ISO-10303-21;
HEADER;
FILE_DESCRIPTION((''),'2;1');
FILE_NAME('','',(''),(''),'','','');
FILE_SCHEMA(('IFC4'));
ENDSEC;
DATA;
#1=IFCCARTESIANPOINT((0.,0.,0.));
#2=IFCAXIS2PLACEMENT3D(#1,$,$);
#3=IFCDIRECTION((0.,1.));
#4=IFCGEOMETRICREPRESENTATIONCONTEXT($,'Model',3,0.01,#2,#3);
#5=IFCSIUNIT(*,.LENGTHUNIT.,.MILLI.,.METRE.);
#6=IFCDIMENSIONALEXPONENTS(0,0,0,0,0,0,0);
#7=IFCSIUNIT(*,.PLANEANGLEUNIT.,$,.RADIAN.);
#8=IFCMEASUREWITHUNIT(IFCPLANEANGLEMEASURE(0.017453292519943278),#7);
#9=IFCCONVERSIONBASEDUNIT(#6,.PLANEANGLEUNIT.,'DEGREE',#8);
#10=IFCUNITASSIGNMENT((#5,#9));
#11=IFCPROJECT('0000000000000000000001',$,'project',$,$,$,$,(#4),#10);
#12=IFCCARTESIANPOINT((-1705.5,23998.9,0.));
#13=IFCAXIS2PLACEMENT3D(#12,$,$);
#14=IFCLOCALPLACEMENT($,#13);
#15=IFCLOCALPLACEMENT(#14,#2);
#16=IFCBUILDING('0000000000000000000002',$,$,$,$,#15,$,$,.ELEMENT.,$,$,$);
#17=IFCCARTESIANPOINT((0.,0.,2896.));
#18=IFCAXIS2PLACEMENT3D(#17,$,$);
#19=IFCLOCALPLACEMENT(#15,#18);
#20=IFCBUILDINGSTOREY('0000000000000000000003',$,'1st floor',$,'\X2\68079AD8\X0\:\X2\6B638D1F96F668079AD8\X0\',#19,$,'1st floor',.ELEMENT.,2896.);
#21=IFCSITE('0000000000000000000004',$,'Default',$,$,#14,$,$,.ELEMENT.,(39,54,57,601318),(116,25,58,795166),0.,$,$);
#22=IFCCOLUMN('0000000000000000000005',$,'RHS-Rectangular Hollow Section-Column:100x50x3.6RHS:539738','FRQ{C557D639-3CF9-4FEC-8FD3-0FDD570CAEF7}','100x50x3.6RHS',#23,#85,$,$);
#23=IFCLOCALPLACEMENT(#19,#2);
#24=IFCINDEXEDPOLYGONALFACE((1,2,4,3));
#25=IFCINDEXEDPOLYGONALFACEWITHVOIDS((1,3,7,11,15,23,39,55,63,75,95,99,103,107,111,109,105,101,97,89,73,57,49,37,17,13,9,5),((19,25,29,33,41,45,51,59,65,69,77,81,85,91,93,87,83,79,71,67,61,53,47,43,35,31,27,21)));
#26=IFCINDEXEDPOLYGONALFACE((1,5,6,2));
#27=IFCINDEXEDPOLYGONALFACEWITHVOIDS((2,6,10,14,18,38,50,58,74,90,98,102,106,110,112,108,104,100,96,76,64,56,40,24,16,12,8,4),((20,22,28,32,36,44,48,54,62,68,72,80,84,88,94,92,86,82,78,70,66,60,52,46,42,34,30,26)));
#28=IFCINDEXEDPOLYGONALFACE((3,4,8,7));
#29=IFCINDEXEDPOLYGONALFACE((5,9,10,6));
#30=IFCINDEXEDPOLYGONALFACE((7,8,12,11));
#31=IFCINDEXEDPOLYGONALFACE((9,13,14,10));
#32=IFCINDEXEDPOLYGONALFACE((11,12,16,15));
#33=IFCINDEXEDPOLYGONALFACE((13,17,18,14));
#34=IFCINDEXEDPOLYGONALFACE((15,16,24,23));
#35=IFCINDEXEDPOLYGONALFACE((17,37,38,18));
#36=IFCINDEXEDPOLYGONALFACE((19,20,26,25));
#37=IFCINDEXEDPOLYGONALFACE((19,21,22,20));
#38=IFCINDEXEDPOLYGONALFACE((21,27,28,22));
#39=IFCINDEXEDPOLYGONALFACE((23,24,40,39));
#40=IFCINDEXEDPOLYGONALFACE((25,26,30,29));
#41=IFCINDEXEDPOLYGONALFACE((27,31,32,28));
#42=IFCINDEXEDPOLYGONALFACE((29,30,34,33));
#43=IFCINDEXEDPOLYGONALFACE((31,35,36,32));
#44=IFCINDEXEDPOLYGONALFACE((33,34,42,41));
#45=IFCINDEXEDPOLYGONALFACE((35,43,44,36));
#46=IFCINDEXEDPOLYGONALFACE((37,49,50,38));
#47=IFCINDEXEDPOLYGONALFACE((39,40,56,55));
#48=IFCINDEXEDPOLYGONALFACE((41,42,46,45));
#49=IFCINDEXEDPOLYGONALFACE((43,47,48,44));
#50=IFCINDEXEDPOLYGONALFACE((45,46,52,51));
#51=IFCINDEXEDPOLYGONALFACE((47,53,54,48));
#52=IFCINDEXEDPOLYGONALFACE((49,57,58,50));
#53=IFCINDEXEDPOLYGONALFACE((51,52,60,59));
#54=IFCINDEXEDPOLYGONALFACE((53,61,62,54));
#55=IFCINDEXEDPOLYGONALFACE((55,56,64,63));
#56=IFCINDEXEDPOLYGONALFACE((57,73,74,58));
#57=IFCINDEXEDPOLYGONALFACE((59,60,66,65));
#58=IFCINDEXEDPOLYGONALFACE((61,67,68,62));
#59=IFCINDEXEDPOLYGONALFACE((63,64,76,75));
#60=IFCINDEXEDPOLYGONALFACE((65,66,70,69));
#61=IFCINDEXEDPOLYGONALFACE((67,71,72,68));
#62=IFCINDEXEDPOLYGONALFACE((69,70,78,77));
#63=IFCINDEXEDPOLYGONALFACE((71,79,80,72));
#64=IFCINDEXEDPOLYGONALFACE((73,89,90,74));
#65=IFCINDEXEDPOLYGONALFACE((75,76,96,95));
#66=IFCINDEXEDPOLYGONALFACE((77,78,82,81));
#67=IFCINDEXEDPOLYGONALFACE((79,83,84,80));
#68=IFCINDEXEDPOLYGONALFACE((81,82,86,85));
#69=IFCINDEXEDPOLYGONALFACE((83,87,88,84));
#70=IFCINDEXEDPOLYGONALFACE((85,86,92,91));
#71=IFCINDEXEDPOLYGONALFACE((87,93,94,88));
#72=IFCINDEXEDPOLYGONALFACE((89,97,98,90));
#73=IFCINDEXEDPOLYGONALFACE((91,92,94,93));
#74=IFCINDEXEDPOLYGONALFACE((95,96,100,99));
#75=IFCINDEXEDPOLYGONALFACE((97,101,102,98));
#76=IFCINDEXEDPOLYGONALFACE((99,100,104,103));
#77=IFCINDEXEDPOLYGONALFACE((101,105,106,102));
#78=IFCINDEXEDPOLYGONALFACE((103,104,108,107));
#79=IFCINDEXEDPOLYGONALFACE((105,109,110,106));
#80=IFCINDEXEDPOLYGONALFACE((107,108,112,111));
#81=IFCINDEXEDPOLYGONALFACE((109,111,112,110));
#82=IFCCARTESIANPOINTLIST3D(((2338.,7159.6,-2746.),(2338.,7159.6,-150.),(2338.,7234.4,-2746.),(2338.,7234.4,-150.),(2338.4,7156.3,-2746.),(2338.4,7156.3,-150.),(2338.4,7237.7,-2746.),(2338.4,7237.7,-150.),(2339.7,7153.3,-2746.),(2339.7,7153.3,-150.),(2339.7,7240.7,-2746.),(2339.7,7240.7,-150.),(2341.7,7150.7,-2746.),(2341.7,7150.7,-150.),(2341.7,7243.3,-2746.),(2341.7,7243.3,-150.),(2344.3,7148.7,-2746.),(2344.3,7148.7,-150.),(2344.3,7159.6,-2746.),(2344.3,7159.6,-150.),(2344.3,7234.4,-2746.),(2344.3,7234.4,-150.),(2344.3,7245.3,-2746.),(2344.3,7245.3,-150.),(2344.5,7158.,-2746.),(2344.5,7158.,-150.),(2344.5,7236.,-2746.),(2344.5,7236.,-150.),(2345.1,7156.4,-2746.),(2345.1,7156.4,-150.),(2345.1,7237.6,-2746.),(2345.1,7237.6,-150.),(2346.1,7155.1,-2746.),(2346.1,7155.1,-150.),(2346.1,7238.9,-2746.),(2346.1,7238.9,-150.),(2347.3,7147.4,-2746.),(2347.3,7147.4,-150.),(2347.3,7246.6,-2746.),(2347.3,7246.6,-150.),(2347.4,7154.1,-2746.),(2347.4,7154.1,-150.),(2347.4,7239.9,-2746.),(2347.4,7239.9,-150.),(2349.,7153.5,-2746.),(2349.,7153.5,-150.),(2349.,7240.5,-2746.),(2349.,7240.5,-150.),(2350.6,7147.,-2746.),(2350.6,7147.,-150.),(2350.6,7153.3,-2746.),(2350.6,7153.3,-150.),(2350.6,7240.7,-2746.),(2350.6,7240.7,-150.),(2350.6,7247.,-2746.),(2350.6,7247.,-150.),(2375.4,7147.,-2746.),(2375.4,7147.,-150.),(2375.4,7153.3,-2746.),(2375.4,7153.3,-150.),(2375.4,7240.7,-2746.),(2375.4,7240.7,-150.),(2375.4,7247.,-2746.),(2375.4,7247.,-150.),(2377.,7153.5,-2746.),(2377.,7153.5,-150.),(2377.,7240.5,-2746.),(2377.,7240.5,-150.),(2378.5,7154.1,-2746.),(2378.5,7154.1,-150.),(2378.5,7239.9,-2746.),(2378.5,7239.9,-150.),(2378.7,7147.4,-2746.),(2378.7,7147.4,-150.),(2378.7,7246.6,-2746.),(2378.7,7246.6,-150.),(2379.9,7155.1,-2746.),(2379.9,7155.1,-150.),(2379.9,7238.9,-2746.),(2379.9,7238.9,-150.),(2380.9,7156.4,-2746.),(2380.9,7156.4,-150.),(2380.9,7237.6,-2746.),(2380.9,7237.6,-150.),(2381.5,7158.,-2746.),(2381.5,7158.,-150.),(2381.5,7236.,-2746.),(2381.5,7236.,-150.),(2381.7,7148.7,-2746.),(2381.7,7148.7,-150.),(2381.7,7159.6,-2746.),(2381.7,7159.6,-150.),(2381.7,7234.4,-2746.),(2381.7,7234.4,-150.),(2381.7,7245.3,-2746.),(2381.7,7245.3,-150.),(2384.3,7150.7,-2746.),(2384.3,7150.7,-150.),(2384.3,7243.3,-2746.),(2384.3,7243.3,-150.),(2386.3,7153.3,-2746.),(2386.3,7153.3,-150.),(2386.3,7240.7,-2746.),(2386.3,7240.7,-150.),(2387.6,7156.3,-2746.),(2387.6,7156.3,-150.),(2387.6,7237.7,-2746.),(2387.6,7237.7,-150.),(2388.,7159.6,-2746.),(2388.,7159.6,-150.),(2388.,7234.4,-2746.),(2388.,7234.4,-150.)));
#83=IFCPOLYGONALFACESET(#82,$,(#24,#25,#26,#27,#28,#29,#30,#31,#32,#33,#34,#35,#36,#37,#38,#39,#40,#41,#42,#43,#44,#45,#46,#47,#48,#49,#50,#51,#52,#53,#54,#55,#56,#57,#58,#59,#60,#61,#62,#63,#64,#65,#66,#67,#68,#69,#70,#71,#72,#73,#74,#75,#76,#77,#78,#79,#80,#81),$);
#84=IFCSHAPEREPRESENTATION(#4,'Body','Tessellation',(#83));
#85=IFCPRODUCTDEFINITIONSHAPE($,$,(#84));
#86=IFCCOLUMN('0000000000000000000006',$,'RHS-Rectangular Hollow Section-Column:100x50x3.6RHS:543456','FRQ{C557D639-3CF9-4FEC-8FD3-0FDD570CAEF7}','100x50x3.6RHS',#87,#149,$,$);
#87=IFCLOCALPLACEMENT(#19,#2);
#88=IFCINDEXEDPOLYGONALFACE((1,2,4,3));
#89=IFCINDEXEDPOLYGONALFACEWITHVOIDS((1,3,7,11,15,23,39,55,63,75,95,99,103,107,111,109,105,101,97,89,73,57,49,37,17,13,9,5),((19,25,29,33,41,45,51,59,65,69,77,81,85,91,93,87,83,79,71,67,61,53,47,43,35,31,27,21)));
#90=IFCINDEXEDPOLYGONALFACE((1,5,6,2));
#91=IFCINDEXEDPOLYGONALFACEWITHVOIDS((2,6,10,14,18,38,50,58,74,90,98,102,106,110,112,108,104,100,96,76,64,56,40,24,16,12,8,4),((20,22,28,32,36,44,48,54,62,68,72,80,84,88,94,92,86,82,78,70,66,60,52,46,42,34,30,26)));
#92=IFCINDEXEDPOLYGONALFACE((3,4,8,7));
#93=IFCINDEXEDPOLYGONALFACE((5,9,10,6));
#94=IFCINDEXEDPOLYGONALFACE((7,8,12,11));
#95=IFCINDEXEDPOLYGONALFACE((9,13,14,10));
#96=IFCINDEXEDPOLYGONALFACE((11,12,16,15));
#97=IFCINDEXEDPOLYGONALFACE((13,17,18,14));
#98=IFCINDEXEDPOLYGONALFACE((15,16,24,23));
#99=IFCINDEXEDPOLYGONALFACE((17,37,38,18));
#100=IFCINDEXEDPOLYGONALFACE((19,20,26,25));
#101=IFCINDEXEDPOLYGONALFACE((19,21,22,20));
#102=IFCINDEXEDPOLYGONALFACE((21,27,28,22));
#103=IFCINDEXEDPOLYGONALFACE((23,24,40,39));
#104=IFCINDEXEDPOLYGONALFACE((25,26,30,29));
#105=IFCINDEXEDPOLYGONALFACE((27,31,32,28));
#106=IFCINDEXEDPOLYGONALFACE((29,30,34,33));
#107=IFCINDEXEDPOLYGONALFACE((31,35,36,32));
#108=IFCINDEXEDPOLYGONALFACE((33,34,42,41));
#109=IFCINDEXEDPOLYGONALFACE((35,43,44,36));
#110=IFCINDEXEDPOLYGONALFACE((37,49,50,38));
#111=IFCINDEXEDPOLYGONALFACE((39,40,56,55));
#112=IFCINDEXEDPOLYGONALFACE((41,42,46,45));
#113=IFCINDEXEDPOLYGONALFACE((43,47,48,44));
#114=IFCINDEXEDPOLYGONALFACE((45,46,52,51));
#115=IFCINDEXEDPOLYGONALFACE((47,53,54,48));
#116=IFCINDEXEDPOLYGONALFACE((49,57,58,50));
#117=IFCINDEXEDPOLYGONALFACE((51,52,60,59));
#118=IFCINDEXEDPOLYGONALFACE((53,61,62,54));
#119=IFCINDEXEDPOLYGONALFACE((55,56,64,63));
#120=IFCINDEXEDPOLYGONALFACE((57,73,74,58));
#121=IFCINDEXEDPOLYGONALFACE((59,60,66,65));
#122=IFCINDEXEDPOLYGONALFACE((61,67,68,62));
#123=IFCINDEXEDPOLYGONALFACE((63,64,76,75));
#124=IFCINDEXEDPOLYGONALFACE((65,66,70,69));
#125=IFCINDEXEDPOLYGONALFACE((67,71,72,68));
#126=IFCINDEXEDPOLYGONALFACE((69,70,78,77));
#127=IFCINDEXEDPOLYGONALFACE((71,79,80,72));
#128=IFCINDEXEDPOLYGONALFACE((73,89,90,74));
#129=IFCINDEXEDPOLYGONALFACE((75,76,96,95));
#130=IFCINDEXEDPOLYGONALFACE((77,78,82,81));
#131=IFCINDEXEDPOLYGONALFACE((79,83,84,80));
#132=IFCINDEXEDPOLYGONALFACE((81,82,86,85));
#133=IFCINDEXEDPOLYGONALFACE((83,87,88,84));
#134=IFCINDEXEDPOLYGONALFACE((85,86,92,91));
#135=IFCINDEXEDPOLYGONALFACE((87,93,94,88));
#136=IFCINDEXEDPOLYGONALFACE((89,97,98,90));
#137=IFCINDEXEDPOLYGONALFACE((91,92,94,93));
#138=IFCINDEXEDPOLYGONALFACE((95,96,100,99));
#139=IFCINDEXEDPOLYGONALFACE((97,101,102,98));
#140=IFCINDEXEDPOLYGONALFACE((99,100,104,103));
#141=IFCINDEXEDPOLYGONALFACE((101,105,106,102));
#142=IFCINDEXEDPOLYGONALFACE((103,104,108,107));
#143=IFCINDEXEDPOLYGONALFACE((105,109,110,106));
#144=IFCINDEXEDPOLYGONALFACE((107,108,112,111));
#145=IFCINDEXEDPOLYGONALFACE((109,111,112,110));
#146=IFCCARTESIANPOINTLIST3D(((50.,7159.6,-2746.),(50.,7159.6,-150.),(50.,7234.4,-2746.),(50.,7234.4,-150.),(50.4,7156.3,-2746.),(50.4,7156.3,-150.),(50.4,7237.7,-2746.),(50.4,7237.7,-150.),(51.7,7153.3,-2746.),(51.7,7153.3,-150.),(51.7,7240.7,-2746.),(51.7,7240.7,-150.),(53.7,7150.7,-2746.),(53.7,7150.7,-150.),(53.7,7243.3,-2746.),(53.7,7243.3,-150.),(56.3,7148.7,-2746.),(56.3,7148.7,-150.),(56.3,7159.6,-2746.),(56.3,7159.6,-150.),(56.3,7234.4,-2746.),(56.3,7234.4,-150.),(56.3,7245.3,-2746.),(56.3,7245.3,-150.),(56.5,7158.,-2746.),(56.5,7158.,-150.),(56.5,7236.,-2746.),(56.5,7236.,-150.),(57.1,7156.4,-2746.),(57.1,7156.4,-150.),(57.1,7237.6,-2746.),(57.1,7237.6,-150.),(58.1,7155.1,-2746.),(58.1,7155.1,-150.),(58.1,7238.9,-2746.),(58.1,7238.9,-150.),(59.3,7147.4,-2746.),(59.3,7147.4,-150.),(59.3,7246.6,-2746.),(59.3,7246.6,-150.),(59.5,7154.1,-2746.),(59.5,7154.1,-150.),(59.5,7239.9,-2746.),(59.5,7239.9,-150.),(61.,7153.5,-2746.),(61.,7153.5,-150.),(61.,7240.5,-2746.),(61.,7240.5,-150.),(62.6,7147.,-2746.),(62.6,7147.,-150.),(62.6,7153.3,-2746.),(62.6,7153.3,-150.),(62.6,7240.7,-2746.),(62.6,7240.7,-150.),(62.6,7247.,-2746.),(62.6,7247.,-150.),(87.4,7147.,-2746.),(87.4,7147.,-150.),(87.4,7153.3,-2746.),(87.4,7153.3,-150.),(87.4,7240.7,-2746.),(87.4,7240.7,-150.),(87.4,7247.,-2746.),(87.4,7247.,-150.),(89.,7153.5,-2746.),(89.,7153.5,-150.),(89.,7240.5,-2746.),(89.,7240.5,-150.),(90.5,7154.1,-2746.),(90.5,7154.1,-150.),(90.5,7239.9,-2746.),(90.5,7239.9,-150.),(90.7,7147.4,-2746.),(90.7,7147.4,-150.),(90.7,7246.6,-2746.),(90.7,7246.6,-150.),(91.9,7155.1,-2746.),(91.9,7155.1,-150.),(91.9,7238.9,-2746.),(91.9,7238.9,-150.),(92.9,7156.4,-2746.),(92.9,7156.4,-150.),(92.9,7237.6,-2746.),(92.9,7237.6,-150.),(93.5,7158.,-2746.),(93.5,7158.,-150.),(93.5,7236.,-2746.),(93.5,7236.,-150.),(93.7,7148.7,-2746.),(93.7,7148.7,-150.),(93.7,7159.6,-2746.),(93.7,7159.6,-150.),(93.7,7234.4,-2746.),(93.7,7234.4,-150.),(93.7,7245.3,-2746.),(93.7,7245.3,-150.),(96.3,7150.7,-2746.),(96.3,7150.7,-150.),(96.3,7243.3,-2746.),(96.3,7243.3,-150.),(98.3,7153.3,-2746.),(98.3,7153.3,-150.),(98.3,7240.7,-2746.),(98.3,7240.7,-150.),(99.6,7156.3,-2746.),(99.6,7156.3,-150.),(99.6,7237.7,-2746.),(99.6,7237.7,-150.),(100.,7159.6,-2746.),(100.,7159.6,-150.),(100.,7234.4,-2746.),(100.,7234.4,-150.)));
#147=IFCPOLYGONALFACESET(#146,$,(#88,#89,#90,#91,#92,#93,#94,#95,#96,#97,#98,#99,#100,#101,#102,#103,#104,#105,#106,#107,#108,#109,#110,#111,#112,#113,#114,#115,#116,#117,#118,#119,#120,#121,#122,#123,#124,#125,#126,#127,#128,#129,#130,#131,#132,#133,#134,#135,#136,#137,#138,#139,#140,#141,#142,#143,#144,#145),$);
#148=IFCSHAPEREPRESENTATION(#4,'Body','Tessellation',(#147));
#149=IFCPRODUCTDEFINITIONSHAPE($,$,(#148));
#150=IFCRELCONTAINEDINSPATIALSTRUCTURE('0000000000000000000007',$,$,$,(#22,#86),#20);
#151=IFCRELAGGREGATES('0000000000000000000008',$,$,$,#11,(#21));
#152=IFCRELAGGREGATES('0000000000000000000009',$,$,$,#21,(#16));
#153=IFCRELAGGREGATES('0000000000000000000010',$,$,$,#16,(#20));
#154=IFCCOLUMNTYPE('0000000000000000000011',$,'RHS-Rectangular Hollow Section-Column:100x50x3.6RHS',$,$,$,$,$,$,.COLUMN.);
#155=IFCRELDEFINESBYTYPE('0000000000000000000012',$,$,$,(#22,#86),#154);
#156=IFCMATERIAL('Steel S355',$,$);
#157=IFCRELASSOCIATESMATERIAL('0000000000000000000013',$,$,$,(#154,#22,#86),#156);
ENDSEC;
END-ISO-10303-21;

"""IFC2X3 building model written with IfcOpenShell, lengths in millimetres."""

from ifc_helpers import new_model, entity, si_unit, converted_unit, direction, frame, origin, origin_2d, place, context, project, spatial, hollow_rectangle, extrude, clip, halfspace, material, type_object, element, save


model = new_model("IFC2X3")

# Units and contexts
model_context = context("Model", 3, precision=0.01, world=origin(), true_north=direction((0.0, 1.0)))
ifc_project = project(units=[si_unit("LENGTHUNIT", "METRE", prefix="MILLI"), converted_unit("PLANEANGLEUNIT", "DEGREE", entity("IfcPlaneAngleMeasure", 0.017453292519943278), si_unit("PLANEANGLEUNIT", "RADIAN"), dimensions=[0, 0, 0, 0, 0, 0, 0])], contexts=[model_context])

# Site, building, storey
site_placement = place(None, frame((-1705.5, 23998.9, 0.0)))
site = spatial("IfcSite", under=ifc_project, at=site_placement, Name="Default", CompositionType="ELEMENT", RefLatitude=(39, 54, 57, 601318), RefLongitude=(116, 25, 58, 795166), RefElevation=0.0)
building_placement = place(site_placement, origin())
building = spatial("IfcBuilding", under=site, at=building_placement, CompositionType="ELEMENT")
storey_placement = place(building_placement, frame((0.0, 0.0, 2896.0)))
storey = spatial("IfcBuildingStorey", under=building, at=storey_placement, Name="1st floor", ObjectType="标高:正负零标高", LongName="1st floor", CompositionType="ELEMENT", Elevation=2896.0)

# Columns
ifc_material_1 = material(Name="Steel S355")
column_type = type_object("IfcColumnType", Name="RHS-Rectangular Hollow Section-Column:100x50x3.6RHS", PredefinedType="COLUMN", material=ifc_material_1)
column_1_placement = place(storey_placement, frame((2363.0, 7197.0, -150.0), z_axis=(0.0, 0.0, 1.0), x_axis=(-1.0, 0.0, 0.0)))
element("IfcColumn", 1, at=column_1_placement, inside=storey, type_object=column_type, material=ifc_material_1, Name="RHS-Rectangular Hollow Section-Column:100x50x3.6RHS:539738", Description="FRQ{C557D639-3CF9-4FEC-8FD3-0FDD570CAEF7}", ObjectType="100x50x3.6RHS", context=model_context, shape_type="Clipping", body=[
    clip(extrude(hollow_rectangle(XDim=50.0, YDim=100.0, WallThickness=6.3, InnerFilletRadius=6.3, OuterFilletRadius=12.6, at=origin_2d()), origin(), (0.0, 0.0, -1.0), 2651.9), halfspace(frame((2363.0, 7197.0, -2596.0), z_axis=(0.0, 0.0, 1.0), x_axis=(-1.0, 0.0, 0.0)), True)),
])
column_2_placement = place(storey_placement, frame((75.0, 7197.0, -150.0), z_axis=(0.0, 0.0, 1.0), x_axis=(-1.0, 0.0, 0.0)))
element("IfcColumn", 2, at=column_2_placement, inside=storey, type_object=column_type, material=ifc_material_1, Name="RHS-Rectangular Hollow Section-Column:100x50x3.6RHS:543456", Description="FRQ{C557D639-3CF9-4FEC-8FD3-0FDD570CAEF7}", ObjectType="100x50x3.6RHS", context=model_context, shape_type="Clipping", body=[
    clip(extrude(hollow_rectangle(XDim=50.0, YDim=100.0, WallThickness=6.3, InnerFilletRadius=6.3, OuterFilletRadius=12.6, at=origin_2d()), origin(), (0.0, 0.0, -1.0), 2651.9), halfspace(frame((75.0, 7197.0, -2596.0), z_axis=(0.0, 0.0, 1.0), x_axis=(-1.0, 0.0, 0.0)), True)),
])

save(model, "model.ifc")
